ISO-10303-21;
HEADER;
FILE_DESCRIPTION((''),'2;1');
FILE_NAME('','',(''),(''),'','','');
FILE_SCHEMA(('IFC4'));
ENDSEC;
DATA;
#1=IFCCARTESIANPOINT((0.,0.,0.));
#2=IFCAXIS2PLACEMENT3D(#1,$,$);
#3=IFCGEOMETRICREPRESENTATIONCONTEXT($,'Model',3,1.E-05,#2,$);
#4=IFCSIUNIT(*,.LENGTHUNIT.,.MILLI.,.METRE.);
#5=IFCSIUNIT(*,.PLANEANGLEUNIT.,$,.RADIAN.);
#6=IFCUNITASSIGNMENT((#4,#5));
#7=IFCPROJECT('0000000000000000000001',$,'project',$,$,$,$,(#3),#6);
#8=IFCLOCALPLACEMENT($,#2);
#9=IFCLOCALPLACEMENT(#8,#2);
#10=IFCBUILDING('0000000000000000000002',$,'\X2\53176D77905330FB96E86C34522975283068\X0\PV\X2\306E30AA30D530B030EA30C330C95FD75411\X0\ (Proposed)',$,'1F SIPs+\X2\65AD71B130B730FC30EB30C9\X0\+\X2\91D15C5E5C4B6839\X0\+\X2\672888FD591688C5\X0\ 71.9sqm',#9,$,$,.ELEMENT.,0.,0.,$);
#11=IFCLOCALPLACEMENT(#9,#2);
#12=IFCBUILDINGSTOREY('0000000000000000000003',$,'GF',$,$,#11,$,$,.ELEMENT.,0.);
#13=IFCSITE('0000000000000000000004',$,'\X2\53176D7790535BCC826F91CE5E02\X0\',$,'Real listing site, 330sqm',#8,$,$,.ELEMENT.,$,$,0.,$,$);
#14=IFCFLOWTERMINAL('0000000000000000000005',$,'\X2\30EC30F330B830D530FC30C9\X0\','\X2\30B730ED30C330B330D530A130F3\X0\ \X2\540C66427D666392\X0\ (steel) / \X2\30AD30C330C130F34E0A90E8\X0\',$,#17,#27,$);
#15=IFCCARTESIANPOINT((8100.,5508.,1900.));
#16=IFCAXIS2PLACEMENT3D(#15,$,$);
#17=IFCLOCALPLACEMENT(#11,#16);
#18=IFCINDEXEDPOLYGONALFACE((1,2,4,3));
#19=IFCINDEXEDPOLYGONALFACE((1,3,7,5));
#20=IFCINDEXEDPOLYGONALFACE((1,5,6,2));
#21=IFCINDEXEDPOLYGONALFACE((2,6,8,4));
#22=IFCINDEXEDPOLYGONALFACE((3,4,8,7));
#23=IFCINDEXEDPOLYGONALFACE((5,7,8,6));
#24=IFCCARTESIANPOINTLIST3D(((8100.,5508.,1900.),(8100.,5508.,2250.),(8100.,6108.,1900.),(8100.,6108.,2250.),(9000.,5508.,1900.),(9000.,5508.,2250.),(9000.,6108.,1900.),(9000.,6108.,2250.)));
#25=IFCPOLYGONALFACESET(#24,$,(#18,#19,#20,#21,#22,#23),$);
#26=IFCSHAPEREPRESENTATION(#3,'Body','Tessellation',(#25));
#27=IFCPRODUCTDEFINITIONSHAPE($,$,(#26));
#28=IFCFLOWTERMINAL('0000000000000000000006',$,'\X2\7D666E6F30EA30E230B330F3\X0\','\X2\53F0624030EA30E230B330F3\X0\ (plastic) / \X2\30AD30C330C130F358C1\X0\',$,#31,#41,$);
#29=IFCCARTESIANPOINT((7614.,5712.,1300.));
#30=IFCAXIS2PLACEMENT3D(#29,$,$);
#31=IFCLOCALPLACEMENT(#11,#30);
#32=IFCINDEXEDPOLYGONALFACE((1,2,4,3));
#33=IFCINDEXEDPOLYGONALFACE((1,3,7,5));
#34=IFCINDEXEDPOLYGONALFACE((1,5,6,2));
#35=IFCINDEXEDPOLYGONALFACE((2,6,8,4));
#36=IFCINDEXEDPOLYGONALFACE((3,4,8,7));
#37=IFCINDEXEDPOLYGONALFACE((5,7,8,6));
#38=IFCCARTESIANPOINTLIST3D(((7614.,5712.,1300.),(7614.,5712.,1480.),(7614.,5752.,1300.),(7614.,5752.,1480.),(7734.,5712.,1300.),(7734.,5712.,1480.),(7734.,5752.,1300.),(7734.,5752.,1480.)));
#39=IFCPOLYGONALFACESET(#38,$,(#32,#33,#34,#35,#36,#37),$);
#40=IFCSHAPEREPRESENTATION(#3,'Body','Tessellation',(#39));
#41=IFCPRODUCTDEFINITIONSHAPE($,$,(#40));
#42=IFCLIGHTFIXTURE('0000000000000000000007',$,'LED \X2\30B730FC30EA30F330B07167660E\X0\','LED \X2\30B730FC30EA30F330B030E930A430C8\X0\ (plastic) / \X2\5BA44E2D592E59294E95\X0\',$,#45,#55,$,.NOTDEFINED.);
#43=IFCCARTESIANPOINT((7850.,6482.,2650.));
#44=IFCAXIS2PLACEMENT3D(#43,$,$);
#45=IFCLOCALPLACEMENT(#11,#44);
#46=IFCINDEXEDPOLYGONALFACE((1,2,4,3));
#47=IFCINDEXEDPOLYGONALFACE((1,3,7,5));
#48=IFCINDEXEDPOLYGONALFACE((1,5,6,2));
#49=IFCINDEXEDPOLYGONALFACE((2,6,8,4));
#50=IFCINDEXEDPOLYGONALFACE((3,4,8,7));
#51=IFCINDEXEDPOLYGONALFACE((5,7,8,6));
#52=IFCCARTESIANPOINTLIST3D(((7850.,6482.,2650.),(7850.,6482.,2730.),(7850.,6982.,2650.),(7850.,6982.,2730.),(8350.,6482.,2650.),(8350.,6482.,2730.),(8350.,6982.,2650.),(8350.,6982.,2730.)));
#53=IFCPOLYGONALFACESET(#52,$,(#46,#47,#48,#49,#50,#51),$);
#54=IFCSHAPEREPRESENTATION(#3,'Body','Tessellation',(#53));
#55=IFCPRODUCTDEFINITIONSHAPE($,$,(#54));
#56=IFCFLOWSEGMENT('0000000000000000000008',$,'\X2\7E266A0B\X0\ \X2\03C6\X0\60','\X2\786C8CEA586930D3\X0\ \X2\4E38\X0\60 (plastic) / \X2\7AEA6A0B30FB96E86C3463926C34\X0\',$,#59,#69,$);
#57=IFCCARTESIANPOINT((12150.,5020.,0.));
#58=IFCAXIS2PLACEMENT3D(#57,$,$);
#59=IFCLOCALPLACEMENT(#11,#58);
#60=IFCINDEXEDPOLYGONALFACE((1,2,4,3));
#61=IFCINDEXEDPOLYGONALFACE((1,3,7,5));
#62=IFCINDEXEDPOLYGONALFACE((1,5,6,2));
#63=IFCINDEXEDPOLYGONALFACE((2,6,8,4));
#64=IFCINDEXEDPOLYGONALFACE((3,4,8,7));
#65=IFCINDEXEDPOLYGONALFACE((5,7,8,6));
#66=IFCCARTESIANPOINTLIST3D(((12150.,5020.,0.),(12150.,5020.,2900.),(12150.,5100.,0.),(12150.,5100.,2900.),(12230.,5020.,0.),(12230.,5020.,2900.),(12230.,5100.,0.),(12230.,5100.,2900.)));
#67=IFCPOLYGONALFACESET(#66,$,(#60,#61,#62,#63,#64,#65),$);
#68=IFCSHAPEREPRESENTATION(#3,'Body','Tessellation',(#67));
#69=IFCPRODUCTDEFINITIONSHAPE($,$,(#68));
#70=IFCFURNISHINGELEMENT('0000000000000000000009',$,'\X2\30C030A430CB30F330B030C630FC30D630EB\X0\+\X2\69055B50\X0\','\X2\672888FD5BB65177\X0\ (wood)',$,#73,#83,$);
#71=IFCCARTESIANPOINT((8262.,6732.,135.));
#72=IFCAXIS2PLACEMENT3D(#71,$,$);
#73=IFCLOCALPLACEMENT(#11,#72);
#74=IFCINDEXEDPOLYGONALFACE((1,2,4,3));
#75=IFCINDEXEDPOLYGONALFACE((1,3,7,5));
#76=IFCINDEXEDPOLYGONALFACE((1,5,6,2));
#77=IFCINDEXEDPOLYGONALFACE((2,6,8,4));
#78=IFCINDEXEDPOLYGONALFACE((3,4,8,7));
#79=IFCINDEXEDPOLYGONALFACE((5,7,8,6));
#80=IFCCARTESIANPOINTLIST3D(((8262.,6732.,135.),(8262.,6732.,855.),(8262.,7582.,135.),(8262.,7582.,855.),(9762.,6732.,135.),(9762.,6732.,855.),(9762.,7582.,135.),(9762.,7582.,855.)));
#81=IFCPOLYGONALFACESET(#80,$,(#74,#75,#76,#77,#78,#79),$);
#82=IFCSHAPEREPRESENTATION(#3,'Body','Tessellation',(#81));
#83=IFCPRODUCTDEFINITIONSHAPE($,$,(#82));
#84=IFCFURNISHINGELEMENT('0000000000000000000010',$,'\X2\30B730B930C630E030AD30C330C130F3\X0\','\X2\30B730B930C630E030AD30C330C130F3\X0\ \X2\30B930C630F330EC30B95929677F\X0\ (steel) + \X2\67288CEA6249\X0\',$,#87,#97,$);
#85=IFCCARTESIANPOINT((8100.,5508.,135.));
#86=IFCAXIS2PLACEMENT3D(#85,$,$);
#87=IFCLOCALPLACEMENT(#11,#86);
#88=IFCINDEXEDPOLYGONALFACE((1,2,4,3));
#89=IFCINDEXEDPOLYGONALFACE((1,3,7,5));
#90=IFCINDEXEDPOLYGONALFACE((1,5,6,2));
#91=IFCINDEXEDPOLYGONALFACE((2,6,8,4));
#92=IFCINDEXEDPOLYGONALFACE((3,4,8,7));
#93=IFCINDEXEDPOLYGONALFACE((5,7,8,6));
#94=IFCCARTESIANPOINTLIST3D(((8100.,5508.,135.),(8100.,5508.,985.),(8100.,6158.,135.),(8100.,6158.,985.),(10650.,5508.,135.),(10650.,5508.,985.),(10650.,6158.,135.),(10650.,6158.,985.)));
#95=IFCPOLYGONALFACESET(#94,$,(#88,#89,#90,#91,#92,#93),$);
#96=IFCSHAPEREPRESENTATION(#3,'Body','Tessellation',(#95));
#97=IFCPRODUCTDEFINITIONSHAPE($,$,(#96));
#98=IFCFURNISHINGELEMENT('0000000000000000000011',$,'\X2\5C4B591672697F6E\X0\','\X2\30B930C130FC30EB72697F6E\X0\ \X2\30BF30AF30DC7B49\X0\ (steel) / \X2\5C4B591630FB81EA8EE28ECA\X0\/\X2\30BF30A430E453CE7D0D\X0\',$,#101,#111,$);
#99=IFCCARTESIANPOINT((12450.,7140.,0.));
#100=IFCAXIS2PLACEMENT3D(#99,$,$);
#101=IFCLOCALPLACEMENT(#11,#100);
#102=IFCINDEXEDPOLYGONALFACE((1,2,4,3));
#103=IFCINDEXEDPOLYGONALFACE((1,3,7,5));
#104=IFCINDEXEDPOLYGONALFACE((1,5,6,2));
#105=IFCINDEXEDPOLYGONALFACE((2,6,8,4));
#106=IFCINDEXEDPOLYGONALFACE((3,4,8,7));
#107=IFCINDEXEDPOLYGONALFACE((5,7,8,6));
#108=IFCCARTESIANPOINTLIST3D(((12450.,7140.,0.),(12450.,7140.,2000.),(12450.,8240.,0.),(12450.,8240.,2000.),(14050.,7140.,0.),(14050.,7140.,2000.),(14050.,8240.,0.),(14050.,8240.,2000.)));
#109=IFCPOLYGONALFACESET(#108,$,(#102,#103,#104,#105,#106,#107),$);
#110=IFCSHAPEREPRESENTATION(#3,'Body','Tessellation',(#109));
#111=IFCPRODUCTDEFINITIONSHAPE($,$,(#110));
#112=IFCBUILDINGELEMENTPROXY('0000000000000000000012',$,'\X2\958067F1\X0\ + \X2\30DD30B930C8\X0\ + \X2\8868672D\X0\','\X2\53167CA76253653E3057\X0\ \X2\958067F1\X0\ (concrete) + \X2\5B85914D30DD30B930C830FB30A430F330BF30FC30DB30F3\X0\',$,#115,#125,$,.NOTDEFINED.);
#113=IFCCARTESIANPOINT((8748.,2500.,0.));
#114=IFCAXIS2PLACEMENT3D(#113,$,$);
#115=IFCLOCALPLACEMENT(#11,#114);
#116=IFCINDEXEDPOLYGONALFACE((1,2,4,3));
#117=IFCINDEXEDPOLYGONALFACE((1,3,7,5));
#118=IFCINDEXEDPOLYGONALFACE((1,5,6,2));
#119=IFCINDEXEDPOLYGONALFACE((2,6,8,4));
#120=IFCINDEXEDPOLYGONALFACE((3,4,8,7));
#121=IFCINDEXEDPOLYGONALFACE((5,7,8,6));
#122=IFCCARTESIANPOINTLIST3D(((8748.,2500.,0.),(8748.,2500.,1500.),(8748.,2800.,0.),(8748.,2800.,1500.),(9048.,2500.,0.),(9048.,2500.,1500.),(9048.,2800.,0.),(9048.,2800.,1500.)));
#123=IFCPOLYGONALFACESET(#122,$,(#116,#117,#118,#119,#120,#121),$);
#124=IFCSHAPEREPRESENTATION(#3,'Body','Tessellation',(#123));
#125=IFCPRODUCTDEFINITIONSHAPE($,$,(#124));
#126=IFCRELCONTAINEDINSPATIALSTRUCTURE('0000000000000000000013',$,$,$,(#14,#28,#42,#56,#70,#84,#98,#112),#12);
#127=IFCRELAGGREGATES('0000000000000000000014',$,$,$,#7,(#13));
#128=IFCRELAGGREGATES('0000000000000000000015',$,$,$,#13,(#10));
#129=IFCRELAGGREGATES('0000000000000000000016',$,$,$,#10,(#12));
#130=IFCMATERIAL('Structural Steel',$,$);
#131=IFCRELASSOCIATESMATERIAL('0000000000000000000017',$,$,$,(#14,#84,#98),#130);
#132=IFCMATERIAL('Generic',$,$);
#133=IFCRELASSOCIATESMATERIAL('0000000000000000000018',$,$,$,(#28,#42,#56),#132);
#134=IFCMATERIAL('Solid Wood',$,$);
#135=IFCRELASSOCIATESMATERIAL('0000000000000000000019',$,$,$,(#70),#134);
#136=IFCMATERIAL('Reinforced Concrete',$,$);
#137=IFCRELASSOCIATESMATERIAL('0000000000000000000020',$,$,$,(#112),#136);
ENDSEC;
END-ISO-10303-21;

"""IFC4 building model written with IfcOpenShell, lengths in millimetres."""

from ifc_helpers import new_model, si_unit, frame, frame_2d, origin, place, context, project, spatial, rectangle, extrude, material, element, save


model = new_model("IFC4")

# Units and contexts
model_context = context("Model", 3, precision=1e-05, world=origin())
ifc_project = project(units=[si_unit("LENGTHUNIT", "METRE", prefix="MILLI"), si_unit("PLANEANGLEUNIT", "RADIAN")], contexts=[model_context])

# Site, building, storey
site_placement = place(None, origin())
site = spatial("IfcSite", under=ifc_project, at=site_placement, Name="北海道富良野市", ObjectType="Real listing site, 330sqm", CompositionType="ELEMENT", RefElevation=0.0)
building_placement = place(site_placement, origin())
building = spatial("IfcBuilding", under=site, at=building_placement, Name="北海道・雨水利用とPVのオフグリッド志向 (Proposed)", ObjectType="1F SIPs+断熱シールド+金属屋根+木製外装 71.9sqm", CompositionType="ELEMENT", ElevationOfRefHeight=0.0, ElevationOfTerrain=0.0)
storey_placement = place(building_placement, origin())
storey = spatial("IfcBuildingStorey", under=building, at=storey_placement, Name="GF", CompositionType="ELEMENT", Elevation=0.0)

# Shared definitions
ifc_material_1 = material(Name="Solid Wood")

# Shared definitions
ifc_material_2 = material(Name="Structural Steel")

# Shared definitions
ifc_material_3 = material(Name="Reinforced Concrete")

# Flow terminals
flow_terminal_1_placement = place(storey_placement, frame((8100.0, 5508.0, 1900.0)))
element("IfcFlowTerminal", 1, at=flow_terminal_1_placement, inside=storey, material=ifc_material_2, Name="レンジフード", Description="シロッコファン 同時給排 (steel) / キッチン上部", context=model_context, shape_type="SweptSolid", body=[
    extrude(rectangle(XDim=900.0, YDim=600.0, at=frame_2d((450.0, 300.0))), frame((8100.0, 5508.0, 1900.0)), (0.0, 0.0, 1.0), 350.0),
])
ifc_material_4 = material(Name="Generic")
flow_terminal_2_placement = place(storey_placement, frame((7614.0, 5712.0, 1300.0)))
element("IfcFlowTerminal", 2, at=flow_terminal_2_placement, inside=storey, material=ifc_material_4, Name="給湯リモコン", Description="台所リモコン (plastic) / キッチン壁", context=model_context, shape_type="SweptSolid", body=[
    extrude(rectangle(XDim=120.0, YDim=40.0, at=frame_2d((60.0, 20.0))), frame((7614.0, 5712.0, 1300.0)), (0.0, 0.0, 1.0), 180.0),
])

# Light fixture
light_fixture_placement = place(storey_placement, frame((7850.0, 6482.0, 2650.0)))
element("IfcLightFixture", 3, at=light_fixture_placement, inside=storey, material=ifc_material_4, Name="LED シーリング照明", Description="LED シーリングライト (plastic) / 室中央天井", PredefinedType="NOTDEFINED", context=model_context, shape_type="SweptSolid", body=[
    extrude(rectangle(XDim=500.0, YDim=500.0, at=frame_2d((250.0, 250.0))), frame((7850.0, 6482.0, 2650.0)), (0.0, 0.0, 1.0), 80.0),
])

# Flow segment
flow_segment_placement = place(storey_placement, frame((12150.0, 5020.0, 0.0)))
element("IfcFlowSegment", 4, at=flow_segment_placement, inside=storey, material=ifc_material_4, Name="縦樋 φ60", Description="硬質塩ビ 丸60 (plastic) / 竪樋・雨水排水", context=model_context, shape_type="SweptSolid", body=[
    extrude(rectangle(XDim=80.0, YDim=80.0, at=frame_2d((40.0, 40.0))), frame((12150.0, 5020.0, 0.0)), (0.0, 0.0, 1.0), 2900.0),
])

# Furnishing elements
furnishing_1_placement = place(storey_placement, frame((8262.0, 6732.0, 135.0)))
element("IfcFurnishingElement", 5, at=furnishing_1_placement, inside=storey, material=ifc_material_1, Name="ダイニングテーブル+椅子", Description="木製家具 (wood)", context=model_context, shape_type="SweptSolid", body=[
    extrude(rectangle(XDim=1500.0, YDim=850.0, at=frame_2d((750.0, 425.0))), frame((8262.0, 6732.0, 135.0)), (0.0, 0.0, 1.0), 720.0),
])
furnishing_2_placement = place(storey_placement, frame((8100.0, 5508.0, 135.0)))
element("IfcFurnishingElement", 6, at=furnishing_2_placement, inside=storey, material=ifc_material_2, Name="システムキッチン", Description="システムキッチン ステンレス天板 (steel) + 木質扉", context=model_context, shape_type="SweptSolid", body=[
    extrude(rectangle(XDim=2550.0, YDim=650.0, at=frame_2d((1275.0, 325.0))), frame((8100.0, 5508.0, 135.0)), (0.0, 0.0, 1.0), 850.0),
])
furnishing_3_placement = place(storey_placement, frame((12450.0, 7140.0, 0.0)))
element("IfcFurnishingElement", 7, at=furnishing_3_placement, inside=storey, material=ifc_material_2, Name="屋外物置", Description="スチール物置 タクボ等 (steel) / 屋外・自転車/タイヤ収納", context=model_context, shape_type="SweptSolid", body=[
    extrude(rectangle(XDim=1600.0, YDim=1100.0, at=frame_2d((800.0, 550.0))), frame((12450.0, 7140.0, 0.0)), (0.0, 0.0, 1.0), 2000.0),
])

# Building element proxy
proxy_placement = place(storey_placement, frame((8748.0, 2500.0, 0.0)))
element("IfcBuildingElementProxy", 8, at=proxy_placement, inside=storey, material=ifc_material_3, Name="門柱 + ポスト + 表札", Description="化粧打放し 門柱 (concrete) + 宅配ポスト・インターホン", PredefinedType="NOTDEFINED", context=model_context, shape_type="SweptSolid", body=[
    extrude(rectangle(XDim=300.0, YDim=300.0, at=frame_2d((150.0, 150.0))), frame((8748.0, 2500.0, 0.0)), (0.0, 0.0, 1.0), 1500.0),
])

save(model, "model.ifc")
